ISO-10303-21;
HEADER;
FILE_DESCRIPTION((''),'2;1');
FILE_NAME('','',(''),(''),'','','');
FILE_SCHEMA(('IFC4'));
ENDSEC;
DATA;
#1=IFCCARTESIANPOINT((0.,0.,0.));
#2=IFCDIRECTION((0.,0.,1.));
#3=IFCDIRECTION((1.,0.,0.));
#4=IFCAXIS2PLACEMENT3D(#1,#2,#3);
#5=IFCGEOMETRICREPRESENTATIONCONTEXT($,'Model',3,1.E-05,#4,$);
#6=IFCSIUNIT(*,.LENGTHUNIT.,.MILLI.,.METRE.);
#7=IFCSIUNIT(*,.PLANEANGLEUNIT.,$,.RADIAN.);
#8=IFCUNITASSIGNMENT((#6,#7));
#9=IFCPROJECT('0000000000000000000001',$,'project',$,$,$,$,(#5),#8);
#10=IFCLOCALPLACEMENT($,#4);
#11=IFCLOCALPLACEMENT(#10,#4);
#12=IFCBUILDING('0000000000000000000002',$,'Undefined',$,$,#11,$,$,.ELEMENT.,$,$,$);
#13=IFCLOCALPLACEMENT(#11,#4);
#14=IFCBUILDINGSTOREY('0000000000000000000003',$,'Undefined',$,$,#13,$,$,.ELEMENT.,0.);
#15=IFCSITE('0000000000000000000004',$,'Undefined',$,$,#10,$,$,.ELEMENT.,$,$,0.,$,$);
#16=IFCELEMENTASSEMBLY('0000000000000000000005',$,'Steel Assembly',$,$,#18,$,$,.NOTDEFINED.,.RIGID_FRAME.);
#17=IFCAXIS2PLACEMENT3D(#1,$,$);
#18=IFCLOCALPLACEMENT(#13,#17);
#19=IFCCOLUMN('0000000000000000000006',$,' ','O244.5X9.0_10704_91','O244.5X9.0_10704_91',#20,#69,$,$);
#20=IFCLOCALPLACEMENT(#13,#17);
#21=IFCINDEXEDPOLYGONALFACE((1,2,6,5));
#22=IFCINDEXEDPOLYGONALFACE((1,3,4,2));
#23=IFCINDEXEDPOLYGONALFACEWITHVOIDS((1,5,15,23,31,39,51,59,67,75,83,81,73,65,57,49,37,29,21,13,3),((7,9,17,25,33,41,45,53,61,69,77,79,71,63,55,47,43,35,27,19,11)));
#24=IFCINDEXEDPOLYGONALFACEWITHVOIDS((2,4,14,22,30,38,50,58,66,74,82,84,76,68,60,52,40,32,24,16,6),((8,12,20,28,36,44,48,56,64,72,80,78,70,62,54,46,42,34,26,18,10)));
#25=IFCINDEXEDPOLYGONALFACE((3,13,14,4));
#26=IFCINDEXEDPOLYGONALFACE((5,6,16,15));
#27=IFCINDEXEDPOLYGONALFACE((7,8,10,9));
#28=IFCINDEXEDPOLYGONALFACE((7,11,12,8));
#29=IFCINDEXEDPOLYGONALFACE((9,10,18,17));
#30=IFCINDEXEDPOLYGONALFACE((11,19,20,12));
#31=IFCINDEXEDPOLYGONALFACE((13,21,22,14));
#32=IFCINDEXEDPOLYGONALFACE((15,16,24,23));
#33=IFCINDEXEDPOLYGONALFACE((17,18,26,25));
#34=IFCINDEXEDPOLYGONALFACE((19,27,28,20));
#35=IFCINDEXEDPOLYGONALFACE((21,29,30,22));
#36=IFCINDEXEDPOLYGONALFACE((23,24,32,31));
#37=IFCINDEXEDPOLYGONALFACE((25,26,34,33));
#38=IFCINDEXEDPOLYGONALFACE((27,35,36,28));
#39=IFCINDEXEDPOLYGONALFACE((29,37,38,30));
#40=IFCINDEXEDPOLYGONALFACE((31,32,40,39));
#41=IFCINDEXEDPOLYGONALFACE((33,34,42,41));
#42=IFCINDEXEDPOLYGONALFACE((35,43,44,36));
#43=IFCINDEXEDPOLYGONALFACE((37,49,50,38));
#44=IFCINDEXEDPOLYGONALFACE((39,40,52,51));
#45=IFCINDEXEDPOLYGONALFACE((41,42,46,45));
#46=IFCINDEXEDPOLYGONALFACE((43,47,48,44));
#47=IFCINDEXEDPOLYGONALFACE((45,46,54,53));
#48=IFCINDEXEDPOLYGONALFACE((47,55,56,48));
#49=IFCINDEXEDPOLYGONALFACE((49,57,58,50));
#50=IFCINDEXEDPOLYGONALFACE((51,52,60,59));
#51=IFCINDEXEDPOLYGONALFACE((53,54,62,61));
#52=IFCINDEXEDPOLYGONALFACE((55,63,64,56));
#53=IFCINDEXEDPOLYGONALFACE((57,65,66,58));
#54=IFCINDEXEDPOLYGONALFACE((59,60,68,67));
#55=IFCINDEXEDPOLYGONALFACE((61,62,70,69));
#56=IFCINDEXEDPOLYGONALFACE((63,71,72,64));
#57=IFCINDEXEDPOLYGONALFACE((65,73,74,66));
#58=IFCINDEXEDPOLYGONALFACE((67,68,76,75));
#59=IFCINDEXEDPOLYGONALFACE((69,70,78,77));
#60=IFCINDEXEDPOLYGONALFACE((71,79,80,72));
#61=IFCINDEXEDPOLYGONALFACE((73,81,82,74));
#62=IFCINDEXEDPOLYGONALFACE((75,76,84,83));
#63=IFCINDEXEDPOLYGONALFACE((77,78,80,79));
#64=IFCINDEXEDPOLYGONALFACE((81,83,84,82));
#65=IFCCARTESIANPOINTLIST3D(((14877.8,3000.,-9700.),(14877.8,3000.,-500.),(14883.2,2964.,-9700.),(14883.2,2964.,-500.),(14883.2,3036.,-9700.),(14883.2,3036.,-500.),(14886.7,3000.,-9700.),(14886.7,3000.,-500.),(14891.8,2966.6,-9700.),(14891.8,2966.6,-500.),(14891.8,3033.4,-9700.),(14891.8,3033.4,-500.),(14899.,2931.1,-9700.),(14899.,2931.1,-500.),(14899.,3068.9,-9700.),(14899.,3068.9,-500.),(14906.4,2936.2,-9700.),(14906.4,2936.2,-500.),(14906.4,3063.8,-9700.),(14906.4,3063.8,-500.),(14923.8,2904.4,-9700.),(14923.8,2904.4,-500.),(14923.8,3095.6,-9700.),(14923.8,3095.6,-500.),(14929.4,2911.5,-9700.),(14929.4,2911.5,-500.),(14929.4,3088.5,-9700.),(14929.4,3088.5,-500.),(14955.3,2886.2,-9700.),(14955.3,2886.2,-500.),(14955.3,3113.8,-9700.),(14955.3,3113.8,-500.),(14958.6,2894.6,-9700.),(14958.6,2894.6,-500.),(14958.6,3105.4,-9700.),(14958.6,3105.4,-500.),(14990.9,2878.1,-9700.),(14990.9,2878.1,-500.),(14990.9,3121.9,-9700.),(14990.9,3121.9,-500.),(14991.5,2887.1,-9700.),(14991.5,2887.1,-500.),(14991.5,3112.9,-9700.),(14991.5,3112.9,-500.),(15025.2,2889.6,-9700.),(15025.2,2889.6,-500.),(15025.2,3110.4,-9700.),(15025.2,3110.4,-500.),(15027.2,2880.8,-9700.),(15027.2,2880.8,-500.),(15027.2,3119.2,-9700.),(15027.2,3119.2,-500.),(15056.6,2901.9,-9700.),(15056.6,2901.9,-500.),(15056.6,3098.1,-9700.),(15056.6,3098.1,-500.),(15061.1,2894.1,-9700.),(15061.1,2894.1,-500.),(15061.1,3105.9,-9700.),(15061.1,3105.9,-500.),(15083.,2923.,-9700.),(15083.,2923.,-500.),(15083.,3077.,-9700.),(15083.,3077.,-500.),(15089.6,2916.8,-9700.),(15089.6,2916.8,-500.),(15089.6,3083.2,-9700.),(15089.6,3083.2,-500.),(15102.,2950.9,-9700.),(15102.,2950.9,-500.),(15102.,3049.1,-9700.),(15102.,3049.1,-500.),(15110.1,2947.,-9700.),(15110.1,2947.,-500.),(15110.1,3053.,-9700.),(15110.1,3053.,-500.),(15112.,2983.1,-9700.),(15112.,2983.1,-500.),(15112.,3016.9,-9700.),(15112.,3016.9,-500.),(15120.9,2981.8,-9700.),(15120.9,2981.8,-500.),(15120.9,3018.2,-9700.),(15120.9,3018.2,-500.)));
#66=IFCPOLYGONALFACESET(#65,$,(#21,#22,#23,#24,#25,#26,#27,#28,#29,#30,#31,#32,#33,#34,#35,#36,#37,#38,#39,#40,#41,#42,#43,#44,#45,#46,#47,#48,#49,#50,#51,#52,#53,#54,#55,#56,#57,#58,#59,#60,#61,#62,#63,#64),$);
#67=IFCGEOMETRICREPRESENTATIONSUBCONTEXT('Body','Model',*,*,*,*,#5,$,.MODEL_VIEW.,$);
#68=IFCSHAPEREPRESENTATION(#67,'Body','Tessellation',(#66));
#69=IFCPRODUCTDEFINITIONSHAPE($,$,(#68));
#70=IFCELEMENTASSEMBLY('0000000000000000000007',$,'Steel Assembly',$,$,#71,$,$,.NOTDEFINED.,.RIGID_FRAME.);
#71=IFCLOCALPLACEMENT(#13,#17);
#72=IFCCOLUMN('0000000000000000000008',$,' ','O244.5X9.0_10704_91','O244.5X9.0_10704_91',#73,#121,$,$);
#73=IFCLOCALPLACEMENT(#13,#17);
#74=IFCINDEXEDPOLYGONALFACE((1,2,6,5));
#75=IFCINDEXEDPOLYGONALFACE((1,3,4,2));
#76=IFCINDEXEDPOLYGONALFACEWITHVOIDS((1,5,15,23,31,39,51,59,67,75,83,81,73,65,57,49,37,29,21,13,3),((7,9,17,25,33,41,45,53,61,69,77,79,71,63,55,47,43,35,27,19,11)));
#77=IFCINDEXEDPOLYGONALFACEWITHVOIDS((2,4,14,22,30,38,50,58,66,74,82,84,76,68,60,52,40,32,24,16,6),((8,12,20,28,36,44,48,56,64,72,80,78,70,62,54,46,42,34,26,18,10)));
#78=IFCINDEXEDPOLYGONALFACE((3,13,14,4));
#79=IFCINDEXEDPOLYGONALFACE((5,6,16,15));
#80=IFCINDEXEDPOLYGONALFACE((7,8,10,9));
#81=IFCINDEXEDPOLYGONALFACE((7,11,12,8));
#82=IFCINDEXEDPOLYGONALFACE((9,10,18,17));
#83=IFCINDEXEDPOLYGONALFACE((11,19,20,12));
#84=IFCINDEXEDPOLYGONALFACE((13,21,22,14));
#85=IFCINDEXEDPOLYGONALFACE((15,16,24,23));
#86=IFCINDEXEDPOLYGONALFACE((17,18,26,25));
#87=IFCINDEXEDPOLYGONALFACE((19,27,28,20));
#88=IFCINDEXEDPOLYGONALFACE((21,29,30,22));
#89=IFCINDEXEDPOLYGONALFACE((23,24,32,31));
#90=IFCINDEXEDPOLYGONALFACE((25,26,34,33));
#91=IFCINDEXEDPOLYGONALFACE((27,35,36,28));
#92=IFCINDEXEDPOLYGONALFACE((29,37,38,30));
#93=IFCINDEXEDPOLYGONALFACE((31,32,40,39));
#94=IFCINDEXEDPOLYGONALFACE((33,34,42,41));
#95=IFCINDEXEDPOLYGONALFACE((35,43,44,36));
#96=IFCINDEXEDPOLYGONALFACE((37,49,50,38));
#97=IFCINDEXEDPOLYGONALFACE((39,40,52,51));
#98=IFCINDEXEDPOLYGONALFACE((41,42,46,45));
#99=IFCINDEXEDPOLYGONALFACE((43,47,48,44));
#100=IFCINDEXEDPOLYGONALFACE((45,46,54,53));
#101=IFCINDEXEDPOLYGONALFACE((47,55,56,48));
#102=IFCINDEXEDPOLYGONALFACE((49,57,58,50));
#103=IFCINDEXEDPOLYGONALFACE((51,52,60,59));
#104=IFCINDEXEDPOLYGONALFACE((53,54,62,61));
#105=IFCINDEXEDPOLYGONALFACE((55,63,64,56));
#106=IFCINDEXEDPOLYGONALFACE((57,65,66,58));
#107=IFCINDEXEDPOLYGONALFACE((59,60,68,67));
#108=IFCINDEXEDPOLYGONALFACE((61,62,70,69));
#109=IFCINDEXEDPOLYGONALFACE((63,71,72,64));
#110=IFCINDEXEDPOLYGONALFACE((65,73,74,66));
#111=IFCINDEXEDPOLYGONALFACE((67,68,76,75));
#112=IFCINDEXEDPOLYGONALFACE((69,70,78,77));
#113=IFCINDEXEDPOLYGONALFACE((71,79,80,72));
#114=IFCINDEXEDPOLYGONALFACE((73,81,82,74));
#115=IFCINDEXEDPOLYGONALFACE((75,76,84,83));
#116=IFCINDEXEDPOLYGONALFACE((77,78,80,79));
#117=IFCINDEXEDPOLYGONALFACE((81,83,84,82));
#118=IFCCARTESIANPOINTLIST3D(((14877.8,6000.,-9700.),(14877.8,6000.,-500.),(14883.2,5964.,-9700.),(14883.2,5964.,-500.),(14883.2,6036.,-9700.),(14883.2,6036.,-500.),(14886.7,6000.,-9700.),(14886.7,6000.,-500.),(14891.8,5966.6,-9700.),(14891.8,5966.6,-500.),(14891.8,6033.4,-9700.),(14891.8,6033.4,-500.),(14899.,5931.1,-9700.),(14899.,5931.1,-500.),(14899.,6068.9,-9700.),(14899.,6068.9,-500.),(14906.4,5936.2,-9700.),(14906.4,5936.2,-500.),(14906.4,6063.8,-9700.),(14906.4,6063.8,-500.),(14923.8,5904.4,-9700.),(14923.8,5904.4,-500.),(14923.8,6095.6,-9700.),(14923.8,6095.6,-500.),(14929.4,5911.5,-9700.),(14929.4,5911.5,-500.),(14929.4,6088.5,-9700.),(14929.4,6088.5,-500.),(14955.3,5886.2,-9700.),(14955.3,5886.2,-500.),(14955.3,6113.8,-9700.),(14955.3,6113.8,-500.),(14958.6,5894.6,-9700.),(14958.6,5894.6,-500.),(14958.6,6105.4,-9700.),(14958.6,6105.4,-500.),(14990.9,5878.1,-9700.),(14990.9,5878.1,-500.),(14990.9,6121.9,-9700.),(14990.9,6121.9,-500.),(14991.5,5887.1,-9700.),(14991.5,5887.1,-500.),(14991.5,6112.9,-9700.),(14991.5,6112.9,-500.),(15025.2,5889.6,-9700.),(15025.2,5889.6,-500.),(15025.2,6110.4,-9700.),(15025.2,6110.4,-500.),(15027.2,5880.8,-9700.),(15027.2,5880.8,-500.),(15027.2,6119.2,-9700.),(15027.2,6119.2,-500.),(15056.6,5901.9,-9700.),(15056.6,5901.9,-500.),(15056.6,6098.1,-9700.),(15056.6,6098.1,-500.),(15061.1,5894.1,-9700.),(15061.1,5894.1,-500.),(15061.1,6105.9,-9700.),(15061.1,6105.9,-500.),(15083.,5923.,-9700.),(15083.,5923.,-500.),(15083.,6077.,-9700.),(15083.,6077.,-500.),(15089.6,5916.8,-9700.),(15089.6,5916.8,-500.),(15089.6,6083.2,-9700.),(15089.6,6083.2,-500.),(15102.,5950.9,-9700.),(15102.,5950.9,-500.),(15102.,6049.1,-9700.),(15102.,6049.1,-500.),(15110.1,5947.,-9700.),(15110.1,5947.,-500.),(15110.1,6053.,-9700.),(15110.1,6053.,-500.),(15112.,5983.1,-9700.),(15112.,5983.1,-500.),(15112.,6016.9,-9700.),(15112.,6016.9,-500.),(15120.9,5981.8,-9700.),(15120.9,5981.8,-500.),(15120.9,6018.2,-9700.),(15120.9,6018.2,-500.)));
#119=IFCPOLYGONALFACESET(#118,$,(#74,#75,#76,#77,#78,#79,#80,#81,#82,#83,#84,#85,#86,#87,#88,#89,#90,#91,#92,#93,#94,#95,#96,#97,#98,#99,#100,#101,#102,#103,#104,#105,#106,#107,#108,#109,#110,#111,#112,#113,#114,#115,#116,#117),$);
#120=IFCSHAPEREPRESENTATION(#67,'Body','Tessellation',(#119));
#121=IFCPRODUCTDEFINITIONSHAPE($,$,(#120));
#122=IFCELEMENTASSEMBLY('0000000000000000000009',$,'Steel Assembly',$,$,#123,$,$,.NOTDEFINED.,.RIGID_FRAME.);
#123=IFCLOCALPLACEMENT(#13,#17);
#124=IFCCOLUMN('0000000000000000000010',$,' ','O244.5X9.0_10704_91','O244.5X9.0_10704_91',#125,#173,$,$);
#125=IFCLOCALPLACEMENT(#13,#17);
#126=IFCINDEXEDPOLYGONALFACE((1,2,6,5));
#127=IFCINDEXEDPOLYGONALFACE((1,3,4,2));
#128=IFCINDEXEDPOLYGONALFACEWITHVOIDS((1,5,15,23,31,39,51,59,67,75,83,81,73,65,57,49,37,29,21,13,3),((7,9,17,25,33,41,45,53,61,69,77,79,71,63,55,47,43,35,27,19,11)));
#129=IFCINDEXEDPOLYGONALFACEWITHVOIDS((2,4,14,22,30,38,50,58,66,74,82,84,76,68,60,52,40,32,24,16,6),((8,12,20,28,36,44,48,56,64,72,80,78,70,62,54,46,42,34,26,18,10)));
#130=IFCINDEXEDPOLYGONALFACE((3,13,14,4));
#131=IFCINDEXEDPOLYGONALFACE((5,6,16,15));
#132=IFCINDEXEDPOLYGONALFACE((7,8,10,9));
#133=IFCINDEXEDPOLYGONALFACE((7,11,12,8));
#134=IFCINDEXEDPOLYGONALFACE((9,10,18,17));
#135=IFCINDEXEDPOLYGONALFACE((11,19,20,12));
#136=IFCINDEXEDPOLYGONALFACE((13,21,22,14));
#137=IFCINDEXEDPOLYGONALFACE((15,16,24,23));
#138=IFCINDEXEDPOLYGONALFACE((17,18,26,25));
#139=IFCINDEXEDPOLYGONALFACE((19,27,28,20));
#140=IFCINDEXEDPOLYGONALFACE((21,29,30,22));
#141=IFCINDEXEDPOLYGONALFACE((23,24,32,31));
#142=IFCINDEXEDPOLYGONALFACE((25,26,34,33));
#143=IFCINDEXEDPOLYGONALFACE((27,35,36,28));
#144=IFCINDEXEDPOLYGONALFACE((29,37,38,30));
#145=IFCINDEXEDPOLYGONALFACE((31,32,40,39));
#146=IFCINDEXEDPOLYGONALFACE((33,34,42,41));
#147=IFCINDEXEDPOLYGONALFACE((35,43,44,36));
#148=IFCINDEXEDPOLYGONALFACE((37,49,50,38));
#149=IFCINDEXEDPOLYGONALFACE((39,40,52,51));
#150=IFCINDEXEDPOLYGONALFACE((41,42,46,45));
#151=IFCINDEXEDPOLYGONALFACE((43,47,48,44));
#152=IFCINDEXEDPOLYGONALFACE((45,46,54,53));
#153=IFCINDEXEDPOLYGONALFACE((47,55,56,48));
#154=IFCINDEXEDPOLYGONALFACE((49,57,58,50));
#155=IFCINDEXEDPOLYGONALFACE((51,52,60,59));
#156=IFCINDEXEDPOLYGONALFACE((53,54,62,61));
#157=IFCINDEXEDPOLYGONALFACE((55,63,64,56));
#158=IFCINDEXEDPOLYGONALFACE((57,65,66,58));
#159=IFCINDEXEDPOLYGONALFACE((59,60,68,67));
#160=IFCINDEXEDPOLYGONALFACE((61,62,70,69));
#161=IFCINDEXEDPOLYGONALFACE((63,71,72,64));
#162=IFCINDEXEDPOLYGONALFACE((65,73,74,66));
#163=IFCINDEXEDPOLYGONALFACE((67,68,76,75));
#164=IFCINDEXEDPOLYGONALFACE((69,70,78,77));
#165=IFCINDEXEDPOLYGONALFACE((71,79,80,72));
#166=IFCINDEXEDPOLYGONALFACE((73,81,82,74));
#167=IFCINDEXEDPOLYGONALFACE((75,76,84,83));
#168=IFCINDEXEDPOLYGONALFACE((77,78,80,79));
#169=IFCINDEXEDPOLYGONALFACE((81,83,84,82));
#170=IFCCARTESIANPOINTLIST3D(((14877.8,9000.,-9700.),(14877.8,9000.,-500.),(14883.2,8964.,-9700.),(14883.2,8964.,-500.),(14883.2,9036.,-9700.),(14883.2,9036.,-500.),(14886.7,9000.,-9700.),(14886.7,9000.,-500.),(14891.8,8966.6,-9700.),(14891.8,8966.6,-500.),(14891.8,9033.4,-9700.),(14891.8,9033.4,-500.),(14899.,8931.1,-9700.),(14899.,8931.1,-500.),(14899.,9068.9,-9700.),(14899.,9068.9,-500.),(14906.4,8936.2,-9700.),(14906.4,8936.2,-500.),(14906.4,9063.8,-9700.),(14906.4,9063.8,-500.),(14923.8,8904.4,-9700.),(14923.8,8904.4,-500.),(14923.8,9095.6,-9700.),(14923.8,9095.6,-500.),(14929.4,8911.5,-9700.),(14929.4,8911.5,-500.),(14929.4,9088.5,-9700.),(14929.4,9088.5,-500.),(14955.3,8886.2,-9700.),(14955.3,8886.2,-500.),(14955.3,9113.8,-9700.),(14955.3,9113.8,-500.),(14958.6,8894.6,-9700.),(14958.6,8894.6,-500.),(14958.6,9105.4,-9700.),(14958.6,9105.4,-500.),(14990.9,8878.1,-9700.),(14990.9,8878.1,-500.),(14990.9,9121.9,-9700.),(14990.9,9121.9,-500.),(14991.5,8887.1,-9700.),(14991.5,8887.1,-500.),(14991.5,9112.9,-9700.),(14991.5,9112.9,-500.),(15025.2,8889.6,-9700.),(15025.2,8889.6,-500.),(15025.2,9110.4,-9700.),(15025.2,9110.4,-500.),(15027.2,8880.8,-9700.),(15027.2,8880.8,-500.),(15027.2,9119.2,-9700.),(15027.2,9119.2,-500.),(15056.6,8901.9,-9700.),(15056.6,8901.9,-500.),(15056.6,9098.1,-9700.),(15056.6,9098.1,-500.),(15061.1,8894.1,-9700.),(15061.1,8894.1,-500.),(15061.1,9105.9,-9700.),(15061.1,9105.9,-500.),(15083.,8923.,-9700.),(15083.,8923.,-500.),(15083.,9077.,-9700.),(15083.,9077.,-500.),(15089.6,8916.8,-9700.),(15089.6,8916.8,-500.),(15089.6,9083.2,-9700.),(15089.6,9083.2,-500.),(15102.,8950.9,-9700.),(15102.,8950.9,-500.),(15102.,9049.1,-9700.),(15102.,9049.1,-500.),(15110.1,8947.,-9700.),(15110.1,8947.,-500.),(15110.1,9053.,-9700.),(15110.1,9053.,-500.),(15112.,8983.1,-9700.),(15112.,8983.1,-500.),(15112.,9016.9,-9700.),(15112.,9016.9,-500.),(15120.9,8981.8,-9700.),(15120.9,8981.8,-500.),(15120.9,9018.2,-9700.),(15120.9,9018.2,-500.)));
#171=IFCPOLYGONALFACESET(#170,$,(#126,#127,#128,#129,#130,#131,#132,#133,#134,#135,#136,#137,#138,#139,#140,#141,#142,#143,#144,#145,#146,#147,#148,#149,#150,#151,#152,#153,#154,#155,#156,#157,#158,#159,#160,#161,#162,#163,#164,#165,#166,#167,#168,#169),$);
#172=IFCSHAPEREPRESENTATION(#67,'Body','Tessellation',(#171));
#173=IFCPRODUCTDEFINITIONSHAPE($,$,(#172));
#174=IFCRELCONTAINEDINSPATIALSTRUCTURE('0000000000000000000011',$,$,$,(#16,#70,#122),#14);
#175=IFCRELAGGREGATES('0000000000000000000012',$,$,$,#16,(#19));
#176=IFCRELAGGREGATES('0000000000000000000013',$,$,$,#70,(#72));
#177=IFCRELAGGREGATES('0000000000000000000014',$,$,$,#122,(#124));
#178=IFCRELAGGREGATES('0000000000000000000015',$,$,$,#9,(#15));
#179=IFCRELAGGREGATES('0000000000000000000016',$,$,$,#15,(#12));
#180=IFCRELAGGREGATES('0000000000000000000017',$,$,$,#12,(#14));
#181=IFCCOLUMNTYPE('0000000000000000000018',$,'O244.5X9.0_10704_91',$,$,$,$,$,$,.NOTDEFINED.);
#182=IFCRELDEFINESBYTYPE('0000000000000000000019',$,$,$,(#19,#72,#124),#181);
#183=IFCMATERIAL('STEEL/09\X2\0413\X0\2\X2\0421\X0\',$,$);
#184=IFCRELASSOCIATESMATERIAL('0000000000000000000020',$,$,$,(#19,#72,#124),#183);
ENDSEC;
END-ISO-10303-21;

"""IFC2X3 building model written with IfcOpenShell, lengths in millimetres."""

from ifc_helpers import new_model, si_unit, frame, origin_with_axes, origin_2d_with_axis, place, context, subcontext, project, spatial, hollow_circle, extrude, material, type_object, element, aggregate, save


model = new_model("IFC2X3")

# Units and contexts
model_context = context("Model", 3, precision=1e-05, world=origin_with_axes())
body_context = subcontext(model_context, "Body", "Model", "MODEL_VIEW")
ifc_project = project(units=[si_unit("LENGTHUNIT", "METRE", prefix="MILLI"), si_unit("PLANEANGLEUNIT", "RADIAN")], contexts=[model_context])

# Site, building, storey
site_placement = place(None, origin_with_axes())
site = spatial("IfcSite", under=ifc_project, at=site_placement, Name="Undefined", CompositionType="ELEMENT", RefElevation=0.0)
building_placement = place(site_placement, origin_with_axes())
building = spatial("IfcBuilding", under=site, at=building_placement, Name="Undefined", CompositionType="ELEMENT")
storey_placement = place(building_placement, origin_with_axes())
storey = spatial("IfcBuildingStorey", under=building, at=storey_placement, Name="Undefined", CompositionType="ELEMENT", Elevation=0.0)

# Element assemblies, columns
assembly_1_placement = place(storey_placement, origin_with_axes())
assembly_1 = element("IfcElementAssembly", 1, at=assembly_1_placement, inside=storey, Name="Steel Assembly", AssemblyPlace="NOTDEFINED", PredefinedType="RIGID_FRAME")
ifc_material_1 = material(Name="STEEL/09Г2С")
column_type_1 = type_object("IfcColumnType", Name="O244.5X9.0_10704_91", PredefinedType="NOTDEFINED")
column_1_placement = place(assembly_1_placement, frame((15000.0, 3000.0, -9700.0), z_axis=(0.0, 0.0, 1.0), x_axis=(0.0, 1.0, 0.0)))
column_1 = element("IfcColumn", 2, at=column_1_placement, type_object=column_type_1, material=ifc_material_1, Name=" ", Description="O244.5X9.0_10704_91", ObjectType="O244.5X9.0_10704_91", context=body_context, shape_type="SweptSolid", body=[
    extrude(hollow_circle(Radius=122.2, WallThickness=9.0, at=origin_2d_with_axis()), frame((0.0, 0.0, 9200.0), z_axis=(0.0, 0.0, -1.0), x_axis=(0.0, 1.0, 0.0)), (0.0, 0.0, 1.0), 9200.0),
])
aggregate(assembly_1, [column_1])
assembly_2_placement = place(storey_placement, origin_with_axes())
assembly_2 = element("IfcElementAssembly", 3, at=assembly_2_placement, inside=storey, Name="Steel Assembly", AssemblyPlace="NOTDEFINED", PredefinedType="RIGID_FRAME")
column_2_placement = place(assembly_2_placement, frame((15000.0, 6000.0, -9700.0), z_axis=(0.0, 0.0, 1.0), x_axis=(0.0, 1.0, 0.0)))
column_2 = element("IfcColumn", 4, at=column_2_placement, type_object=column_type_1, material=ifc_material_1, Name=" ", Description="O244.5X9.0_10704_91", ObjectType="O244.5X9.0_10704_91", context=body_context, shape_type="SweptSolid", body=[
    extrude(hollow_circle(Radius=122.2, WallThickness=9.0, at=origin_2d_with_axis()), frame((0.0, 0.0, 9200.0), z_axis=(0.0, 0.0, -1.0), x_axis=(0.0, 1.0, 0.0)), (0.0, 0.0, 1.0), 9200.0),
])
aggregate(assembly_2, [column_2])
assembly_3_placement = place(storey_placement, origin_with_axes())
assembly_3 = element("IfcElementAssembly", 5, at=assembly_3_placement, inside=storey, Name="Steel Assembly", AssemblyPlace="NOTDEFINED", PredefinedType="RIGID_FRAME")
column_3_placement = place(assembly_3_placement, frame((15000.0, 9000.0, -9700.0), z_axis=(0.0, 0.0, 1.0), x_axis=(0.0, 1.0, 0.0)))
column_3 = element("IfcColumn", 6, at=column_3_placement, type_object=column_type_1, material=ifc_material_1, Name=" ", Description="O244.5X9.0_10704_91", ObjectType="O244.5X9.0_10704_91", context=body_context, shape_type="SweptSolid", body=[
    extrude(hollow_circle(Radius=122.2, WallThickness=9.0, at=origin_2d_with_axis()), frame((0.0, 0.0, 9200.0), z_axis=(0.0, 0.0, -1.0), x_axis=(0.0, 1.0, 0.0)), (0.0, 0.0, 1.0), 9200.0),
])
aggregate(assembly_3, [column_3])

save(model, "model.ifc")
